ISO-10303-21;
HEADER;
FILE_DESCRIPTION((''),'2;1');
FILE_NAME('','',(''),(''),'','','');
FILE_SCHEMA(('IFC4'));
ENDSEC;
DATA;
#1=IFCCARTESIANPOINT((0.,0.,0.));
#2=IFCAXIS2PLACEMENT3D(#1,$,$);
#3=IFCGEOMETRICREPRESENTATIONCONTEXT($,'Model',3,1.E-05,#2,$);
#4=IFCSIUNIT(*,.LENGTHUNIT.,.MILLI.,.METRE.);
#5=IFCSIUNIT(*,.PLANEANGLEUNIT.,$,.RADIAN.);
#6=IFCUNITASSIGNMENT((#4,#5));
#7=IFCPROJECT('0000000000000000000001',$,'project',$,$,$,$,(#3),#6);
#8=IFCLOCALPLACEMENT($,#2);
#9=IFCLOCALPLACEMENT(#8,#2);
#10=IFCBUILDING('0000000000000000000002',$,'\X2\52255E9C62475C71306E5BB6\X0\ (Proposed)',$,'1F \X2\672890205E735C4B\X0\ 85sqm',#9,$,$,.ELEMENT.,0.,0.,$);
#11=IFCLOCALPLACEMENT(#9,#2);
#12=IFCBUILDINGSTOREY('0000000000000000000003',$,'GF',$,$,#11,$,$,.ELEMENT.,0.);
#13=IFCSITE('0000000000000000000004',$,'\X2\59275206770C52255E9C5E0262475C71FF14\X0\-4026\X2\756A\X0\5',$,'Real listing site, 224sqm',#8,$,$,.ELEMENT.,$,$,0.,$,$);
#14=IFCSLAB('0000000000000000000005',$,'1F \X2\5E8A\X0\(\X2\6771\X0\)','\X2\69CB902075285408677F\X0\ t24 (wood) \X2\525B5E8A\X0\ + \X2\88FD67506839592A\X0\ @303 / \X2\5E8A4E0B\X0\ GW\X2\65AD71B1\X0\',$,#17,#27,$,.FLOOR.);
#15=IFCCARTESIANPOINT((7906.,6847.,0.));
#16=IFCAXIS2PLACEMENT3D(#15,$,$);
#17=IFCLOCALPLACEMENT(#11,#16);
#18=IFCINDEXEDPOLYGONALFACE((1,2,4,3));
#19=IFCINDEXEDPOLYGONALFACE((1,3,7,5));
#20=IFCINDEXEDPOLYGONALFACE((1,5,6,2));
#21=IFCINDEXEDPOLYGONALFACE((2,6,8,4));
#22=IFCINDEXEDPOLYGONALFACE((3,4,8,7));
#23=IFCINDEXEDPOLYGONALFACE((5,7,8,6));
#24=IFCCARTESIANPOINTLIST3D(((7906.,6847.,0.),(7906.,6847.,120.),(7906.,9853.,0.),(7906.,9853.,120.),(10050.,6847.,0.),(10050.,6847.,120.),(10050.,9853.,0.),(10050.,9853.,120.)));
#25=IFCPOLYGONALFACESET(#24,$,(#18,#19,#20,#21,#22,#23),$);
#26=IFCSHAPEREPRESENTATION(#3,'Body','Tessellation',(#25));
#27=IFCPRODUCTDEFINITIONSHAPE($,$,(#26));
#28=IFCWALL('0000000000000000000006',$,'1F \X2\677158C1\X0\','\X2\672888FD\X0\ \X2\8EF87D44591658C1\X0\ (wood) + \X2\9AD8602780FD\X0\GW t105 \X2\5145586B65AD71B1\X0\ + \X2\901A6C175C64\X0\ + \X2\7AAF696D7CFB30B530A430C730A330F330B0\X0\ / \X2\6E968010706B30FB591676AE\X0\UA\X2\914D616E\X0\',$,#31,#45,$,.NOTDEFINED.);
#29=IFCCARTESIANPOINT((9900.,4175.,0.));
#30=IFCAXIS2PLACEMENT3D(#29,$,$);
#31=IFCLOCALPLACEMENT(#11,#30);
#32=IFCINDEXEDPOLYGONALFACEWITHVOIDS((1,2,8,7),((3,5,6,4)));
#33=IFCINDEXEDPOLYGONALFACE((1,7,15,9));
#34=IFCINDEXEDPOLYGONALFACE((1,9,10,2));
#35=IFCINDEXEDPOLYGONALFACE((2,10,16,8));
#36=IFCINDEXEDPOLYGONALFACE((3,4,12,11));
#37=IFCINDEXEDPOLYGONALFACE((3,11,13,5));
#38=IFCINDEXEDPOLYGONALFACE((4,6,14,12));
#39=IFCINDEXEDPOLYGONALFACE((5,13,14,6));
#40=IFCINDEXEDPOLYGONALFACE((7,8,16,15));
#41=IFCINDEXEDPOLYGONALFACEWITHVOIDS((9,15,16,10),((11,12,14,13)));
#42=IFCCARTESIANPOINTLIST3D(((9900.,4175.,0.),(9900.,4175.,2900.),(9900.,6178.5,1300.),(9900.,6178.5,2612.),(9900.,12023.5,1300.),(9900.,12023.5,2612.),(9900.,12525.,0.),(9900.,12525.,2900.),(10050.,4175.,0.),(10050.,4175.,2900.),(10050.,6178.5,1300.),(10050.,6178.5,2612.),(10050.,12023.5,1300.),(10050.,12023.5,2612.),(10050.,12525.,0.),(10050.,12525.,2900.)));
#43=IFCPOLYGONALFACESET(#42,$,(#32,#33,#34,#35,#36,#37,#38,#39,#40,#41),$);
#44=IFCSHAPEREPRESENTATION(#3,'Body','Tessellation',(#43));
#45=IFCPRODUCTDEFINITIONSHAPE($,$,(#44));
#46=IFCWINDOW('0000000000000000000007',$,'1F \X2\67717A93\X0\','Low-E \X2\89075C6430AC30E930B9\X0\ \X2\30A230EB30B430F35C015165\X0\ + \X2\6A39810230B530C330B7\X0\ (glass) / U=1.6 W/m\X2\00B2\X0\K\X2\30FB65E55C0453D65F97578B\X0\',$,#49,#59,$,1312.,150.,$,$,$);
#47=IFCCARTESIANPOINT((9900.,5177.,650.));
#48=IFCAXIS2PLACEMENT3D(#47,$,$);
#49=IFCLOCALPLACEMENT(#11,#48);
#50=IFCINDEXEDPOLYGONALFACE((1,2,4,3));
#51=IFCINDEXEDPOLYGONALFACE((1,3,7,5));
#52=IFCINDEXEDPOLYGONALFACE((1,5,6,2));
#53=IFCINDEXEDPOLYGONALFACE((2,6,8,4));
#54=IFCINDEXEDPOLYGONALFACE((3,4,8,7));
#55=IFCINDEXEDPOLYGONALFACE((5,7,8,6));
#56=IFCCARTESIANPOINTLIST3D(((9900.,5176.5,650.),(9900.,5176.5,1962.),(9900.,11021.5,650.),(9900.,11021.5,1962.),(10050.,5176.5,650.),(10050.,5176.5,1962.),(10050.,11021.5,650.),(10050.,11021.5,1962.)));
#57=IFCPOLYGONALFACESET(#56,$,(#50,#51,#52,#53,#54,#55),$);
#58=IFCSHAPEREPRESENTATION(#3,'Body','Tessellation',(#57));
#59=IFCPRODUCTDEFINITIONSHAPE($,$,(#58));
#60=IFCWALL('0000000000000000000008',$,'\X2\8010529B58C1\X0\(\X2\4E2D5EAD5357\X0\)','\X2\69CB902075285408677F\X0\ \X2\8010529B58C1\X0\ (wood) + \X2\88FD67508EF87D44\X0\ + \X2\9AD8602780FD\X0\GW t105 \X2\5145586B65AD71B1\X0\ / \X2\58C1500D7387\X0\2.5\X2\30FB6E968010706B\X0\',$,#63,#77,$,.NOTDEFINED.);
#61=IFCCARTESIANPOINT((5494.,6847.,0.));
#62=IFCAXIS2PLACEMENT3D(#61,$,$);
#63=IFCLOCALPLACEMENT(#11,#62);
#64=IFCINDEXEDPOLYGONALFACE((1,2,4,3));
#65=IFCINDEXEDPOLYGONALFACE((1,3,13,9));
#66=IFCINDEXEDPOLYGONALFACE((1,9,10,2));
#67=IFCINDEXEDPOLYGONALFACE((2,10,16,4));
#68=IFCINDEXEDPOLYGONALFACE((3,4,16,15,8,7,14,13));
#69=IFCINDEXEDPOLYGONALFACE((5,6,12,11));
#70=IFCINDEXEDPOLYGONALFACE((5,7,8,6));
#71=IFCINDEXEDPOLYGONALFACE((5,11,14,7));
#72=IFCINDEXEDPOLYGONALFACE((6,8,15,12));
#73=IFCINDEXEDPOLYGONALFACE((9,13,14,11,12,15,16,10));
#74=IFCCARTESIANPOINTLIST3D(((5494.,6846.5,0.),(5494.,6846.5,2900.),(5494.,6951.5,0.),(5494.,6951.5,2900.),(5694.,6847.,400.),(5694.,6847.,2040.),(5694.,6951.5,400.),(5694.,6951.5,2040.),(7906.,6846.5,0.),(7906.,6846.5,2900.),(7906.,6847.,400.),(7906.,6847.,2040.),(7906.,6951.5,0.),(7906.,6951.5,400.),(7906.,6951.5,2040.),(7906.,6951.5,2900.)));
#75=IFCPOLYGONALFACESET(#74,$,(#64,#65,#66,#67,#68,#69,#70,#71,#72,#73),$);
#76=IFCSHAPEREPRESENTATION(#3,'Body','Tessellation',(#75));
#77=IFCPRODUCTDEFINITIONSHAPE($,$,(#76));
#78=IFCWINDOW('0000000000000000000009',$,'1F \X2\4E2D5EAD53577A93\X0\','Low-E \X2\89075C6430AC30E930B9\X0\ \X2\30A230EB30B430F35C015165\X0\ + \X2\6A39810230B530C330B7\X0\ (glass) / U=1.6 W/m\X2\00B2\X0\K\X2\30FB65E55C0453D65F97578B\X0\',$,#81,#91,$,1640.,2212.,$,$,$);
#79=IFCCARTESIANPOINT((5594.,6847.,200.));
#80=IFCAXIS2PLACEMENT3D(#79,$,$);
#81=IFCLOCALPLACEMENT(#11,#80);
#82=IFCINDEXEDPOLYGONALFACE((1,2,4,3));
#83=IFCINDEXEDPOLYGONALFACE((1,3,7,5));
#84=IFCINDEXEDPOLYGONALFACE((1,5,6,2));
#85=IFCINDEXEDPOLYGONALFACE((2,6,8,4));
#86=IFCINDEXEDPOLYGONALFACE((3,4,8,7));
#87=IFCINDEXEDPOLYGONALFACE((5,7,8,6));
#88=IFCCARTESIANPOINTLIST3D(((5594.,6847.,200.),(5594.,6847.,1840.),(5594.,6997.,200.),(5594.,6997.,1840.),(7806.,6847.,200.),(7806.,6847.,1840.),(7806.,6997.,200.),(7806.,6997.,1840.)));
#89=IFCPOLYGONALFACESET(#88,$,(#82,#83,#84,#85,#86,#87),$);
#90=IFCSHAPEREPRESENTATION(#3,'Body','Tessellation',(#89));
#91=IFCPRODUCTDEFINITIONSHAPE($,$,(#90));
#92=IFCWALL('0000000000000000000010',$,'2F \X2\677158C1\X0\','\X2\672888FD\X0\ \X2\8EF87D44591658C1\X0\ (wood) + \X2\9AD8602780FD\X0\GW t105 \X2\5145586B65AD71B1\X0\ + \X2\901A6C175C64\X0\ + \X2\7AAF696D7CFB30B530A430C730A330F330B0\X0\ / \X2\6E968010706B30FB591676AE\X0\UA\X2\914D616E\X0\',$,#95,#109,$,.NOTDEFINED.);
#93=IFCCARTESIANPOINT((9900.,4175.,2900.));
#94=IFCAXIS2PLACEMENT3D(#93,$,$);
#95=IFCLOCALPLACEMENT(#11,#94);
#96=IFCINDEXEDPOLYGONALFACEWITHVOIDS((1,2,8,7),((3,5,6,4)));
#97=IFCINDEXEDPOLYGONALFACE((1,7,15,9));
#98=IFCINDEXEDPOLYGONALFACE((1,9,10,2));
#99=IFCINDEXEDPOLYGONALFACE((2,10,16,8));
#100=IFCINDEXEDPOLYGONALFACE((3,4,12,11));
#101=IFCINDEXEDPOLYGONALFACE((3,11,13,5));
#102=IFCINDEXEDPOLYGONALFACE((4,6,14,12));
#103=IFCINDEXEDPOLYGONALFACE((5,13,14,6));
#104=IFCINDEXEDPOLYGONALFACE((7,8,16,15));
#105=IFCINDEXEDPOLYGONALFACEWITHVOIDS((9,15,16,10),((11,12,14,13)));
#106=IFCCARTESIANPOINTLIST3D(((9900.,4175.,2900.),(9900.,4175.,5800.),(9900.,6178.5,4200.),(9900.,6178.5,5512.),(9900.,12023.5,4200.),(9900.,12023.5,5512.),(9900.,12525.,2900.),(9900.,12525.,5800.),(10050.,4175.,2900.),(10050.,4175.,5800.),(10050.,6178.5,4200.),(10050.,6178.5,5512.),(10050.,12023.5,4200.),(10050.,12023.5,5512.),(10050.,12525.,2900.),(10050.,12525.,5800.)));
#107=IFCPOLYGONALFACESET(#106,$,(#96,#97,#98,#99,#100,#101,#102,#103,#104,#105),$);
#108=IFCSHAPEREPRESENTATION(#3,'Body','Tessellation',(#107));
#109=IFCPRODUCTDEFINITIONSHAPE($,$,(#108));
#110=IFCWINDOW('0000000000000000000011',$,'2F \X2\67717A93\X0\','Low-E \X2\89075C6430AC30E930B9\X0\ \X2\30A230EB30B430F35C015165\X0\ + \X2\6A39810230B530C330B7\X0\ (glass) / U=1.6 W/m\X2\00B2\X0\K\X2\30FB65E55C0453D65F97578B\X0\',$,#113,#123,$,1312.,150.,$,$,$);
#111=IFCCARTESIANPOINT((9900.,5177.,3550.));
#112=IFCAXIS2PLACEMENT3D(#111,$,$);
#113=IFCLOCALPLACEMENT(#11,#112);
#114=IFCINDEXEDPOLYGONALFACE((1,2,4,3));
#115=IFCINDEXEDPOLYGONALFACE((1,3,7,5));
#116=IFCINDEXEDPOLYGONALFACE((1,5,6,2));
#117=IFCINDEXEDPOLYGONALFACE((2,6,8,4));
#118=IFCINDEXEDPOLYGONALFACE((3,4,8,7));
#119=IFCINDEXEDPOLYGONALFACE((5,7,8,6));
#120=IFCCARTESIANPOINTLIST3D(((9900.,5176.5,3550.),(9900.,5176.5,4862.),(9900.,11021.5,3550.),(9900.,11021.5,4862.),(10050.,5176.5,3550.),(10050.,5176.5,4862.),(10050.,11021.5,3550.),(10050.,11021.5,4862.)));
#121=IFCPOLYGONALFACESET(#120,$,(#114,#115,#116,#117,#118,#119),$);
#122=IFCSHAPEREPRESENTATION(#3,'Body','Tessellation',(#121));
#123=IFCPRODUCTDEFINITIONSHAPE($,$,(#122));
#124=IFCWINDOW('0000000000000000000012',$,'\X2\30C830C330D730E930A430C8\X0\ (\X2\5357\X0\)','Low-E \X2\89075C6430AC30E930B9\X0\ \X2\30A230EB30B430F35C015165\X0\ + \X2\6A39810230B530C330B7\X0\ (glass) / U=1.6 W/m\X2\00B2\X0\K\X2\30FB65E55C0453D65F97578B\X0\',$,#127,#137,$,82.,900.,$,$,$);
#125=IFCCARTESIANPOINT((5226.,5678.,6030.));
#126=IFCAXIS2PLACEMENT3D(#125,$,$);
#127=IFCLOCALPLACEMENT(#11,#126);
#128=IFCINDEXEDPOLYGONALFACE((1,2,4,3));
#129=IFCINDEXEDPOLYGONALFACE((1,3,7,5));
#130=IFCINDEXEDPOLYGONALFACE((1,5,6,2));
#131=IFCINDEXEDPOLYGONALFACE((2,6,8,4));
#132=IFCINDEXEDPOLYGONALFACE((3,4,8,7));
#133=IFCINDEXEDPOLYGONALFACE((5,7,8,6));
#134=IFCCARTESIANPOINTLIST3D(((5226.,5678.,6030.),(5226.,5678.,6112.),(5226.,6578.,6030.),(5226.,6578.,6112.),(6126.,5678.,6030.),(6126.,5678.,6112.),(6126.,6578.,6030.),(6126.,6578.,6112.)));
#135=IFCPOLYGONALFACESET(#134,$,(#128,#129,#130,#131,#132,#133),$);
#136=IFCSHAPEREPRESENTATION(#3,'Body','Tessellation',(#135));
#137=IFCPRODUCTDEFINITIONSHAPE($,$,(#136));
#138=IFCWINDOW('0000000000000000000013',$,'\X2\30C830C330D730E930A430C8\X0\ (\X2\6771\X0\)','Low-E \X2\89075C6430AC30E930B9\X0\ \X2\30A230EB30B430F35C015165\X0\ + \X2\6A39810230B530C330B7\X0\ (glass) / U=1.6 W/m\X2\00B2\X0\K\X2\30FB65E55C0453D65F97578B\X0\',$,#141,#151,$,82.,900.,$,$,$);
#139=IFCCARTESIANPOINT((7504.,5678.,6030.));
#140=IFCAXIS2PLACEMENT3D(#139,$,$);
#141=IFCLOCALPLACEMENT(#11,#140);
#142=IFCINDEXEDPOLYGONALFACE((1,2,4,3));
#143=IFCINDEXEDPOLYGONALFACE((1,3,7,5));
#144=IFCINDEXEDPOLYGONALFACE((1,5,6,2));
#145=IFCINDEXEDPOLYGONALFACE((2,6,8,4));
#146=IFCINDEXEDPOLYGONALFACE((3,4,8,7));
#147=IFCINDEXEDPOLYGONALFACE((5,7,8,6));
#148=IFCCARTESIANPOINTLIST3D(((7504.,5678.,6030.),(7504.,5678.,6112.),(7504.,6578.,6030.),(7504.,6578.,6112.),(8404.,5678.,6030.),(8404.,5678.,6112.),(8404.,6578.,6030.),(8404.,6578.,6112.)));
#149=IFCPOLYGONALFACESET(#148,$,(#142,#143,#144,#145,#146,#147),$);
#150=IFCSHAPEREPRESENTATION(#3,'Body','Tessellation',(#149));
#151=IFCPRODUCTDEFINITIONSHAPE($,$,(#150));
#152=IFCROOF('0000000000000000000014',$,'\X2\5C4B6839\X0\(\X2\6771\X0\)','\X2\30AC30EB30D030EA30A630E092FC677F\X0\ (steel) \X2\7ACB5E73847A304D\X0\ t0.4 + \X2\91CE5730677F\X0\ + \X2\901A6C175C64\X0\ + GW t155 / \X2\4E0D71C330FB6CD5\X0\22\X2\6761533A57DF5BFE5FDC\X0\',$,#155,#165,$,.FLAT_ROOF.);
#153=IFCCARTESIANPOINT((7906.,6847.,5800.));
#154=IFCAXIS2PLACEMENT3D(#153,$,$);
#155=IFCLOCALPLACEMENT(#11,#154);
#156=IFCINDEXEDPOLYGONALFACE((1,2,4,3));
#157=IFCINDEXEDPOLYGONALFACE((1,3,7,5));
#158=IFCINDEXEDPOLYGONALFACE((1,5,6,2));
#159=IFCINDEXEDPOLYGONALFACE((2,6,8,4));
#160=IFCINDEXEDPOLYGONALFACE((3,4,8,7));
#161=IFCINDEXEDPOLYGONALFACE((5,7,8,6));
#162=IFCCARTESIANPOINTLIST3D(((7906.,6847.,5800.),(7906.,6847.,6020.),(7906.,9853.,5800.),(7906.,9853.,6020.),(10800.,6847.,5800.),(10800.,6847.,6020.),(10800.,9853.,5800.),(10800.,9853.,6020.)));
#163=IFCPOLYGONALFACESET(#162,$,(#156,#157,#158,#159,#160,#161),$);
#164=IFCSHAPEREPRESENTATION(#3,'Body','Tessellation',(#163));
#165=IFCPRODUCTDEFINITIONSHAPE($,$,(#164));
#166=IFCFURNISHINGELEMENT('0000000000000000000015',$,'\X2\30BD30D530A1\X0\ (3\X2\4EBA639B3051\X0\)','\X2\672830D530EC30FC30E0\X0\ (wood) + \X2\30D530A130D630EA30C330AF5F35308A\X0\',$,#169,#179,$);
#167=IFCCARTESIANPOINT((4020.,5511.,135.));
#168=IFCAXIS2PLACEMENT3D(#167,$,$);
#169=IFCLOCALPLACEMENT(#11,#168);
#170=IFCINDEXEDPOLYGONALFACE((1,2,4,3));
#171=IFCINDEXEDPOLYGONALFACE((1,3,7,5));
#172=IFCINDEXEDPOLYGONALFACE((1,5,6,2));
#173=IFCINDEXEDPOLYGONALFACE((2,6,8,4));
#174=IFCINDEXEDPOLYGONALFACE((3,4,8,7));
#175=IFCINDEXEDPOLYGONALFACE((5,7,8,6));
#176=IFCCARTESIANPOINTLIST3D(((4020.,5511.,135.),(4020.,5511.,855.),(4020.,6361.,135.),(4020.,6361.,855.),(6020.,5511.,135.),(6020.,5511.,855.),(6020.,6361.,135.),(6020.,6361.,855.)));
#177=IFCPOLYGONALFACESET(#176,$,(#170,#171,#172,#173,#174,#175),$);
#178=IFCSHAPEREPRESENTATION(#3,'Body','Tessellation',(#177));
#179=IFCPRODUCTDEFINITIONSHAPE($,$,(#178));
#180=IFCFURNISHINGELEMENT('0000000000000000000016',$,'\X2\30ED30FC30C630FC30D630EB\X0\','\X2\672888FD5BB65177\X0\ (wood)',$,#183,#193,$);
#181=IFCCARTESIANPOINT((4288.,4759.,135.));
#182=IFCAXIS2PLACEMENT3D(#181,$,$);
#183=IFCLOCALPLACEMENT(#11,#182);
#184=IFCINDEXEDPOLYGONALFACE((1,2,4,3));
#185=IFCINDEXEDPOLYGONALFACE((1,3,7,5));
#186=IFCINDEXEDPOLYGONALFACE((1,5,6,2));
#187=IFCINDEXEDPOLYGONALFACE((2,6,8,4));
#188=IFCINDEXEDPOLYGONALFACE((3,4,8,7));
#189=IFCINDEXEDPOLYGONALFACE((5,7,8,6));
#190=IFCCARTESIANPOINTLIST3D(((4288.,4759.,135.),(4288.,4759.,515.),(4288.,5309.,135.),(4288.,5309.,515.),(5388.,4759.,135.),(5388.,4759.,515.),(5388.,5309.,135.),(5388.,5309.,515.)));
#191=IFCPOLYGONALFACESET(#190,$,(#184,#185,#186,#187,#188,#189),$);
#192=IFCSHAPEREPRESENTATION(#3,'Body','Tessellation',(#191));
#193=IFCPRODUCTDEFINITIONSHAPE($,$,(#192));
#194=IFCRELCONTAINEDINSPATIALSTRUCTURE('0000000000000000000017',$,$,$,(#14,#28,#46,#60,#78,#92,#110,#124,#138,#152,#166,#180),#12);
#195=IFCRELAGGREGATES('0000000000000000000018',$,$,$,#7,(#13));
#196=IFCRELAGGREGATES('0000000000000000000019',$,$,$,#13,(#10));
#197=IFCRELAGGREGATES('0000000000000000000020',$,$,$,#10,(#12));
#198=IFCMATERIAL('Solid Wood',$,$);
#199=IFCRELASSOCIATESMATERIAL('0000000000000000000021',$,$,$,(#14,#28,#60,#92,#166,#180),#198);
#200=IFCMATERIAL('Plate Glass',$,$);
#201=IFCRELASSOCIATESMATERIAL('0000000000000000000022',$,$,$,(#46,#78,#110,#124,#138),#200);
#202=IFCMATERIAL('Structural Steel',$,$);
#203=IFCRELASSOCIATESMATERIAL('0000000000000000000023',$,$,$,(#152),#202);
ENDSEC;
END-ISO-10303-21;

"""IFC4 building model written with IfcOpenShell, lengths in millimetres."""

from ifc_helpers import new_model, si_unit, frame, frame_2d, origin, place, context, project, spatial, rectangle, extrude, material, element, fill, save


model = new_model("IFC4")

# Units and contexts
model_context = context("Model", 3, precision=1e-05, world=origin())
ifc_project = project(units=[si_unit("LENGTHUNIT", "METRE", prefix="MILLI"), si_unit("PLANEANGLEUNIT", "RADIAN")], contexts=[model_context])

# Site, building, storey
site_placement = place(None, origin())
site = spatial("IfcSite", under=ifc_project, at=site_placement, Name="大分県別府市扇山４-4026番5", ObjectType="Real listing site, 224sqm", CompositionType="ELEMENT", RefElevation=0.0)
building_placement = place(site_placement, origin())
building = spatial("IfcBuilding", under=site, at=building_placement, Name="別府扇山の家 (Proposed)", ObjectType="1F 木造平屋 85sqm", CompositionType="ELEMENT", ElevationOfRefHeight=0.0, ElevationOfTerrain=0.0)
storey_placement = place(building_placement, origin())
storey = spatial("IfcBuildingStorey", under=building, at=storey_placement, Name="GF", CompositionType="ELEMENT", Elevation=0.0)

# Slab
ifc_material_1 = material(Name="Solid Wood")
slab_placement = place(storey_placement, frame((7906.0, 6847.0, 0.0)))
element("IfcSlab", 1, at=slab_placement, inside=storey, material=ifc_material_1, Name="1F 床(東)", Description="構造用合板 t24 (wood) 剛床 + 製材根太 @303 / 床下 GW断熱", PredefinedType="FLOOR", context=model_context, shape_type="SweptSolid", body=[
    extrude(rectangle(XDim=2144.0, YDim=3006.0, at=frame_2d((1072.0, 1503.0))), frame((7906.0, 6847.0, 0.0)), (0.0, 0.0, 1.0), 120.0),
])

# Walls, openings, windows
wall_1_placement = place(storey_placement, frame((9900.0, 4175.0, 0.0)))
wall_1 = element("IfcWall", 2, at=wall_1_placement, inside=storey, material=ifc_material_1, Name="1F 東壁", Description="木製 軸組外壁 (wood) + 高性能GW t105 充填断熱 + 通気層 + 窯業系サイディング / 準耐火・外皮UA配慮", PredefinedType="NOTDEFINED", context=model_context, shape_type="SweptSolid", body=[
    extrude(rectangle(XDim=150.0, YDim=8350.0, at=frame_2d((75.0, 4175.0))), frame((9900.0, 4175.0, 0.0)), (0.0, 0.0, 1.0), 2900.0),
])
opening_1_placement = place(storey_placement, frame((9900.0, 5177.0, 650.0)))
opening_1 = element("IfcOpeningElement", 3, at=opening_1_placement, cuts=wall_1, PredefinedType="NOTDEFINED", context=model_context, shape_type="SweptSolid", body=[
    extrude(rectangle(XDim=150.0, YDim=5845.0, at=frame_2d((75.0, 2922.0))), frame((9900.0, 5177.0, 650.0)), (0.0, 0.0, 1.0), 1312.0),
])
ifc_material_2 = material(Name="Plate Glass")
window_1_placement = place(storey_placement, frame((9900.0, 5177.0, 650.0)))
window_1 = element("IfcWindow", 4, at=window_1_placement, inside=storey, material=ifc_material_2, Name="1F 東窓", Description="Low-E 複層ガラス アルゴン封入 + 樹脂サッシ (glass) / U=1.6 W/m²K・日射取得型", OverallHeight=1312.0, OverallWidth=150.0, context=model_context, shape_type="SweptSolid", body=[
    extrude(rectangle(XDim=150.0, YDim=5845.0, at=frame_2d((75.0, 2922.0))), frame((9900.0, 5177.0, 650.0)), (0.0, 0.0, 1.0), 1312.0),
])
fill(opening_1, window_1)
wall_2_placement = place(storey_placement, frame((5494.0, 6847.0, 0.0)))
wall_2 = element("IfcWall", 5, at=wall_2_placement, inside=storey, material=ifc_material_1, Name="耐力壁(中庭南)", Description="構造用合板 耐力壁 (wood) + 製材軸組 + 高性能GW t105 充填断熱 / 壁倍率2.5・準耐火", PredefinedType="NOTDEFINED", context=model_context, shape_type="SweptSolid", body=[
    extrude(rectangle(XDim=2412.0, YDim=105.0, at=frame_2d((1206.0, 52.0))), frame((5494.0, 6847.0, 0.0)), (0.0, 0.0, 1.0), 2900.0),
])
opening_2_placement = place(storey_placement, frame((5594.0, 6847.0, 200.0)))
opening_2 = element("IfcOpeningElement", 6, at=opening_2_placement, cuts=wall_2, PredefinedType="NOTDEFINED", context=model_context, shape_type="SweptSolid", body=[
    extrude(rectangle(XDim=2212.0, YDim=150.0, at=frame_2d((1106.0, 75.0))), frame((5594.0, 6847.0, 200.0)), (0.0, 0.0, 1.0), 1640.0),
])
window_2_placement = place(storey_placement, frame((5594.0, 6847.0, 200.0)))
window_2 = element("IfcWindow", 7, at=window_2_placement, inside=storey, material=ifc_material_2, Name="1F 中庭南窓", Description="Low-E 複層ガラス アルゴン封入 + 樹脂サッシ (glass) / U=1.6 W/m²K・日射取得型", OverallHeight=1640.0, OverallWidth=2212.0, context=model_context, shape_type="SweptSolid", body=[
    extrude(rectangle(XDim=2212.0, YDim=150.0, at=frame_2d((1106.0, 75.0))), frame((5594.0, 6847.0, 200.0)), (0.0, 0.0, 1.0), 1640.0),
])
fill(opening_2, window_2)

# Wall, opening, window
wall_3_placement = place(storey_placement, frame((9900.0, 4175.0, 2900.0)))
wall_3 = element("IfcWall", 8, at=wall_3_placement, inside=storey, material=ifc_material_1, Name="2F 東壁", Description="木製 軸組外壁 (wood) + 高性能GW t105 充填断熱 + 通気層 + 窯業系サイディング / 準耐火・外皮UA配慮", PredefinedType="NOTDEFINED", context=model_context, shape_type="SweptSolid", body=[
    extrude(rectangle(XDim=150.0, YDim=8350.0, at=frame_2d((75.0, 4175.0))), frame((9900.0, 4175.0, 2900.0)), (0.0, 0.0, 1.0), 2900.0),
])
opening_3_placement = place(storey_placement, frame((9900.0, 5177.0, 3550.0)))
opening_3 = element("IfcOpeningElement", 9, at=opening_3_placement, cuts=wall_3, PredefinedType="NOTDEFINED", context=model_context, shape_type="SweptSolid", body=[
    extrude(rectangle(XDim=150.0, YDim=5845.0, at=frame_2d((75.0, 2922.0))), frame((9900.0, 5177.0, 3550.0)), (0.0, 0.0, 1.0), 1312.0),
])
window_3_placement = place(storey_placement, frame((9900.0, 5177.0, 3550.0)))
window_3 = element("IfcWindow", 10, at=window_3_placement, inside=storey, material=ifc_material_2, Name="2F 東窓", Description="Low-E 複層ガラス アルゴン封入 + 樹脂サッシ (glass) / U=1.6 W/m²K・日射取得型", OverallHeight=1312.0, OverallWidth=150.0, context=model_context, shape_type="SweptSolid", body=[
    extrude(rectangle(XDim=150.0, YDim=5845.0, at=frame_2d((75.0, 2922.0))), frame((9900.0, 5177.0, 3550.0)), (0.0, 0.0, 1.0), 1312.0),
])
fill(opening_3, window_3)

# Windows
window_4_placement = place(storey_placement, frame((5226.0, 5678.0, 6030.0)))
element("IfcWindow", 11, at=window_4_placement, inside=storey, material=ifc_material_2, Name="トップライト (南)", Description="Low-E 複層ガラス アルゴン封入 + 樹脂サッシ (glass) / U=1.6 W/m²K・日射取得型", OverallHeight=82.0, OverallWidth=900.0, context=model_context, shape_type="SweptSolid", body=[
    extrude(rectangle(XDim=900.0, YDim=900.0, at=frame_2d((450.0, 450.0))), frame((5226.0, 5678.0, 6030.0)), (0.0, 0.0, 1.0), 82.0),
])
window_5_placement = place(storey_placement, frame((7504.0, 5678.0, 6030.0)))
element("IfcWindow", 12, at=window_5_placement, inside=storey, material=ifc_material_2, Name="トップライト (東)", Description="Low-E 複層ガラス アルゴン封入 + 樹脂サッシ (glass) / U=1.6 W/m²K・日射取得型", OverallHeight=82.0, OverallWidth=900.0, context=model_context, shape_type="SweptSolid", body=[
    extrude(rectangle(XDim=900.0, YDim=900.0, at=frame_2d((450.0, 450.0))), frame((7504.0, 5678.0, 6030.0)), (0.0, 0.0, 1.0), 82.0),
])

# Roof
ifc_material_3 = material(Name="Structural Steel")
roof_placement = place(storey_placement, frame((7906.0, 6847.0, 5800.0)))
element("IfcRoof", 13, at=roof_placement, inside=storey, material=ifc_material_3, Name="屋根(東)", Description="ガルバリウム鋼板 (steel) 立平葺き t0.4 + 野地板 + 通気層 + GW t155 / 不燃・法22条区域対応", PredefinedType="FLAT_ROOF", context=model_context, shape_type="SweptSolid", body=[
    extrude(rectangle(XDim=2894.0, YDim=3006.0, at=frame_2d((1447.0, 1503.0))), frame((7906.0, 6847.0, 5800.0)), (0.0, 0.0, 1.0), 220.0),
])

# Furnishing elements
furnishing_1_placement = place(storey_placement, frame((4020.0, 5511.0, 135.0)))
element("IfcFurnishingElement", 14, at=furnishing_1_placement, inside=storey, material=ifc_material_1, Name="ソファ (3人掛け)", Description="木フレーム (wood) + ファブリック張り", context=model_context, shape_type="SweptSolid", body=[
    extrude(rectangle(XDim=2000.0, YDim=850.0, at=frame_2d((1000.0, 425.0))), frame((4020.0, 5511.0, 135.0)), (0.0, 0.0, 1.0), 720.0),
])
furnishing_2_placement = place(storey_placement, frame((4288.0, 4759.0, 135.0)))
element("IfcFurnishingElement", 15, at=furnishing_2_placement, inside=storey, material=ifc_material_1, Name="ローテーブル", Description="木製家具 (wood)", context=model_context, shape_type="SweptSolid", body=[
    extrude(rectangle(XDim=1100.0, YDim=550.0, at=frame_2d((550.0, 275.0))), frame((4288.0, 4759.0, 135.0)), (0.0, 0.0, 1.0), 380.0),
])

save(model, "model.ifc")
